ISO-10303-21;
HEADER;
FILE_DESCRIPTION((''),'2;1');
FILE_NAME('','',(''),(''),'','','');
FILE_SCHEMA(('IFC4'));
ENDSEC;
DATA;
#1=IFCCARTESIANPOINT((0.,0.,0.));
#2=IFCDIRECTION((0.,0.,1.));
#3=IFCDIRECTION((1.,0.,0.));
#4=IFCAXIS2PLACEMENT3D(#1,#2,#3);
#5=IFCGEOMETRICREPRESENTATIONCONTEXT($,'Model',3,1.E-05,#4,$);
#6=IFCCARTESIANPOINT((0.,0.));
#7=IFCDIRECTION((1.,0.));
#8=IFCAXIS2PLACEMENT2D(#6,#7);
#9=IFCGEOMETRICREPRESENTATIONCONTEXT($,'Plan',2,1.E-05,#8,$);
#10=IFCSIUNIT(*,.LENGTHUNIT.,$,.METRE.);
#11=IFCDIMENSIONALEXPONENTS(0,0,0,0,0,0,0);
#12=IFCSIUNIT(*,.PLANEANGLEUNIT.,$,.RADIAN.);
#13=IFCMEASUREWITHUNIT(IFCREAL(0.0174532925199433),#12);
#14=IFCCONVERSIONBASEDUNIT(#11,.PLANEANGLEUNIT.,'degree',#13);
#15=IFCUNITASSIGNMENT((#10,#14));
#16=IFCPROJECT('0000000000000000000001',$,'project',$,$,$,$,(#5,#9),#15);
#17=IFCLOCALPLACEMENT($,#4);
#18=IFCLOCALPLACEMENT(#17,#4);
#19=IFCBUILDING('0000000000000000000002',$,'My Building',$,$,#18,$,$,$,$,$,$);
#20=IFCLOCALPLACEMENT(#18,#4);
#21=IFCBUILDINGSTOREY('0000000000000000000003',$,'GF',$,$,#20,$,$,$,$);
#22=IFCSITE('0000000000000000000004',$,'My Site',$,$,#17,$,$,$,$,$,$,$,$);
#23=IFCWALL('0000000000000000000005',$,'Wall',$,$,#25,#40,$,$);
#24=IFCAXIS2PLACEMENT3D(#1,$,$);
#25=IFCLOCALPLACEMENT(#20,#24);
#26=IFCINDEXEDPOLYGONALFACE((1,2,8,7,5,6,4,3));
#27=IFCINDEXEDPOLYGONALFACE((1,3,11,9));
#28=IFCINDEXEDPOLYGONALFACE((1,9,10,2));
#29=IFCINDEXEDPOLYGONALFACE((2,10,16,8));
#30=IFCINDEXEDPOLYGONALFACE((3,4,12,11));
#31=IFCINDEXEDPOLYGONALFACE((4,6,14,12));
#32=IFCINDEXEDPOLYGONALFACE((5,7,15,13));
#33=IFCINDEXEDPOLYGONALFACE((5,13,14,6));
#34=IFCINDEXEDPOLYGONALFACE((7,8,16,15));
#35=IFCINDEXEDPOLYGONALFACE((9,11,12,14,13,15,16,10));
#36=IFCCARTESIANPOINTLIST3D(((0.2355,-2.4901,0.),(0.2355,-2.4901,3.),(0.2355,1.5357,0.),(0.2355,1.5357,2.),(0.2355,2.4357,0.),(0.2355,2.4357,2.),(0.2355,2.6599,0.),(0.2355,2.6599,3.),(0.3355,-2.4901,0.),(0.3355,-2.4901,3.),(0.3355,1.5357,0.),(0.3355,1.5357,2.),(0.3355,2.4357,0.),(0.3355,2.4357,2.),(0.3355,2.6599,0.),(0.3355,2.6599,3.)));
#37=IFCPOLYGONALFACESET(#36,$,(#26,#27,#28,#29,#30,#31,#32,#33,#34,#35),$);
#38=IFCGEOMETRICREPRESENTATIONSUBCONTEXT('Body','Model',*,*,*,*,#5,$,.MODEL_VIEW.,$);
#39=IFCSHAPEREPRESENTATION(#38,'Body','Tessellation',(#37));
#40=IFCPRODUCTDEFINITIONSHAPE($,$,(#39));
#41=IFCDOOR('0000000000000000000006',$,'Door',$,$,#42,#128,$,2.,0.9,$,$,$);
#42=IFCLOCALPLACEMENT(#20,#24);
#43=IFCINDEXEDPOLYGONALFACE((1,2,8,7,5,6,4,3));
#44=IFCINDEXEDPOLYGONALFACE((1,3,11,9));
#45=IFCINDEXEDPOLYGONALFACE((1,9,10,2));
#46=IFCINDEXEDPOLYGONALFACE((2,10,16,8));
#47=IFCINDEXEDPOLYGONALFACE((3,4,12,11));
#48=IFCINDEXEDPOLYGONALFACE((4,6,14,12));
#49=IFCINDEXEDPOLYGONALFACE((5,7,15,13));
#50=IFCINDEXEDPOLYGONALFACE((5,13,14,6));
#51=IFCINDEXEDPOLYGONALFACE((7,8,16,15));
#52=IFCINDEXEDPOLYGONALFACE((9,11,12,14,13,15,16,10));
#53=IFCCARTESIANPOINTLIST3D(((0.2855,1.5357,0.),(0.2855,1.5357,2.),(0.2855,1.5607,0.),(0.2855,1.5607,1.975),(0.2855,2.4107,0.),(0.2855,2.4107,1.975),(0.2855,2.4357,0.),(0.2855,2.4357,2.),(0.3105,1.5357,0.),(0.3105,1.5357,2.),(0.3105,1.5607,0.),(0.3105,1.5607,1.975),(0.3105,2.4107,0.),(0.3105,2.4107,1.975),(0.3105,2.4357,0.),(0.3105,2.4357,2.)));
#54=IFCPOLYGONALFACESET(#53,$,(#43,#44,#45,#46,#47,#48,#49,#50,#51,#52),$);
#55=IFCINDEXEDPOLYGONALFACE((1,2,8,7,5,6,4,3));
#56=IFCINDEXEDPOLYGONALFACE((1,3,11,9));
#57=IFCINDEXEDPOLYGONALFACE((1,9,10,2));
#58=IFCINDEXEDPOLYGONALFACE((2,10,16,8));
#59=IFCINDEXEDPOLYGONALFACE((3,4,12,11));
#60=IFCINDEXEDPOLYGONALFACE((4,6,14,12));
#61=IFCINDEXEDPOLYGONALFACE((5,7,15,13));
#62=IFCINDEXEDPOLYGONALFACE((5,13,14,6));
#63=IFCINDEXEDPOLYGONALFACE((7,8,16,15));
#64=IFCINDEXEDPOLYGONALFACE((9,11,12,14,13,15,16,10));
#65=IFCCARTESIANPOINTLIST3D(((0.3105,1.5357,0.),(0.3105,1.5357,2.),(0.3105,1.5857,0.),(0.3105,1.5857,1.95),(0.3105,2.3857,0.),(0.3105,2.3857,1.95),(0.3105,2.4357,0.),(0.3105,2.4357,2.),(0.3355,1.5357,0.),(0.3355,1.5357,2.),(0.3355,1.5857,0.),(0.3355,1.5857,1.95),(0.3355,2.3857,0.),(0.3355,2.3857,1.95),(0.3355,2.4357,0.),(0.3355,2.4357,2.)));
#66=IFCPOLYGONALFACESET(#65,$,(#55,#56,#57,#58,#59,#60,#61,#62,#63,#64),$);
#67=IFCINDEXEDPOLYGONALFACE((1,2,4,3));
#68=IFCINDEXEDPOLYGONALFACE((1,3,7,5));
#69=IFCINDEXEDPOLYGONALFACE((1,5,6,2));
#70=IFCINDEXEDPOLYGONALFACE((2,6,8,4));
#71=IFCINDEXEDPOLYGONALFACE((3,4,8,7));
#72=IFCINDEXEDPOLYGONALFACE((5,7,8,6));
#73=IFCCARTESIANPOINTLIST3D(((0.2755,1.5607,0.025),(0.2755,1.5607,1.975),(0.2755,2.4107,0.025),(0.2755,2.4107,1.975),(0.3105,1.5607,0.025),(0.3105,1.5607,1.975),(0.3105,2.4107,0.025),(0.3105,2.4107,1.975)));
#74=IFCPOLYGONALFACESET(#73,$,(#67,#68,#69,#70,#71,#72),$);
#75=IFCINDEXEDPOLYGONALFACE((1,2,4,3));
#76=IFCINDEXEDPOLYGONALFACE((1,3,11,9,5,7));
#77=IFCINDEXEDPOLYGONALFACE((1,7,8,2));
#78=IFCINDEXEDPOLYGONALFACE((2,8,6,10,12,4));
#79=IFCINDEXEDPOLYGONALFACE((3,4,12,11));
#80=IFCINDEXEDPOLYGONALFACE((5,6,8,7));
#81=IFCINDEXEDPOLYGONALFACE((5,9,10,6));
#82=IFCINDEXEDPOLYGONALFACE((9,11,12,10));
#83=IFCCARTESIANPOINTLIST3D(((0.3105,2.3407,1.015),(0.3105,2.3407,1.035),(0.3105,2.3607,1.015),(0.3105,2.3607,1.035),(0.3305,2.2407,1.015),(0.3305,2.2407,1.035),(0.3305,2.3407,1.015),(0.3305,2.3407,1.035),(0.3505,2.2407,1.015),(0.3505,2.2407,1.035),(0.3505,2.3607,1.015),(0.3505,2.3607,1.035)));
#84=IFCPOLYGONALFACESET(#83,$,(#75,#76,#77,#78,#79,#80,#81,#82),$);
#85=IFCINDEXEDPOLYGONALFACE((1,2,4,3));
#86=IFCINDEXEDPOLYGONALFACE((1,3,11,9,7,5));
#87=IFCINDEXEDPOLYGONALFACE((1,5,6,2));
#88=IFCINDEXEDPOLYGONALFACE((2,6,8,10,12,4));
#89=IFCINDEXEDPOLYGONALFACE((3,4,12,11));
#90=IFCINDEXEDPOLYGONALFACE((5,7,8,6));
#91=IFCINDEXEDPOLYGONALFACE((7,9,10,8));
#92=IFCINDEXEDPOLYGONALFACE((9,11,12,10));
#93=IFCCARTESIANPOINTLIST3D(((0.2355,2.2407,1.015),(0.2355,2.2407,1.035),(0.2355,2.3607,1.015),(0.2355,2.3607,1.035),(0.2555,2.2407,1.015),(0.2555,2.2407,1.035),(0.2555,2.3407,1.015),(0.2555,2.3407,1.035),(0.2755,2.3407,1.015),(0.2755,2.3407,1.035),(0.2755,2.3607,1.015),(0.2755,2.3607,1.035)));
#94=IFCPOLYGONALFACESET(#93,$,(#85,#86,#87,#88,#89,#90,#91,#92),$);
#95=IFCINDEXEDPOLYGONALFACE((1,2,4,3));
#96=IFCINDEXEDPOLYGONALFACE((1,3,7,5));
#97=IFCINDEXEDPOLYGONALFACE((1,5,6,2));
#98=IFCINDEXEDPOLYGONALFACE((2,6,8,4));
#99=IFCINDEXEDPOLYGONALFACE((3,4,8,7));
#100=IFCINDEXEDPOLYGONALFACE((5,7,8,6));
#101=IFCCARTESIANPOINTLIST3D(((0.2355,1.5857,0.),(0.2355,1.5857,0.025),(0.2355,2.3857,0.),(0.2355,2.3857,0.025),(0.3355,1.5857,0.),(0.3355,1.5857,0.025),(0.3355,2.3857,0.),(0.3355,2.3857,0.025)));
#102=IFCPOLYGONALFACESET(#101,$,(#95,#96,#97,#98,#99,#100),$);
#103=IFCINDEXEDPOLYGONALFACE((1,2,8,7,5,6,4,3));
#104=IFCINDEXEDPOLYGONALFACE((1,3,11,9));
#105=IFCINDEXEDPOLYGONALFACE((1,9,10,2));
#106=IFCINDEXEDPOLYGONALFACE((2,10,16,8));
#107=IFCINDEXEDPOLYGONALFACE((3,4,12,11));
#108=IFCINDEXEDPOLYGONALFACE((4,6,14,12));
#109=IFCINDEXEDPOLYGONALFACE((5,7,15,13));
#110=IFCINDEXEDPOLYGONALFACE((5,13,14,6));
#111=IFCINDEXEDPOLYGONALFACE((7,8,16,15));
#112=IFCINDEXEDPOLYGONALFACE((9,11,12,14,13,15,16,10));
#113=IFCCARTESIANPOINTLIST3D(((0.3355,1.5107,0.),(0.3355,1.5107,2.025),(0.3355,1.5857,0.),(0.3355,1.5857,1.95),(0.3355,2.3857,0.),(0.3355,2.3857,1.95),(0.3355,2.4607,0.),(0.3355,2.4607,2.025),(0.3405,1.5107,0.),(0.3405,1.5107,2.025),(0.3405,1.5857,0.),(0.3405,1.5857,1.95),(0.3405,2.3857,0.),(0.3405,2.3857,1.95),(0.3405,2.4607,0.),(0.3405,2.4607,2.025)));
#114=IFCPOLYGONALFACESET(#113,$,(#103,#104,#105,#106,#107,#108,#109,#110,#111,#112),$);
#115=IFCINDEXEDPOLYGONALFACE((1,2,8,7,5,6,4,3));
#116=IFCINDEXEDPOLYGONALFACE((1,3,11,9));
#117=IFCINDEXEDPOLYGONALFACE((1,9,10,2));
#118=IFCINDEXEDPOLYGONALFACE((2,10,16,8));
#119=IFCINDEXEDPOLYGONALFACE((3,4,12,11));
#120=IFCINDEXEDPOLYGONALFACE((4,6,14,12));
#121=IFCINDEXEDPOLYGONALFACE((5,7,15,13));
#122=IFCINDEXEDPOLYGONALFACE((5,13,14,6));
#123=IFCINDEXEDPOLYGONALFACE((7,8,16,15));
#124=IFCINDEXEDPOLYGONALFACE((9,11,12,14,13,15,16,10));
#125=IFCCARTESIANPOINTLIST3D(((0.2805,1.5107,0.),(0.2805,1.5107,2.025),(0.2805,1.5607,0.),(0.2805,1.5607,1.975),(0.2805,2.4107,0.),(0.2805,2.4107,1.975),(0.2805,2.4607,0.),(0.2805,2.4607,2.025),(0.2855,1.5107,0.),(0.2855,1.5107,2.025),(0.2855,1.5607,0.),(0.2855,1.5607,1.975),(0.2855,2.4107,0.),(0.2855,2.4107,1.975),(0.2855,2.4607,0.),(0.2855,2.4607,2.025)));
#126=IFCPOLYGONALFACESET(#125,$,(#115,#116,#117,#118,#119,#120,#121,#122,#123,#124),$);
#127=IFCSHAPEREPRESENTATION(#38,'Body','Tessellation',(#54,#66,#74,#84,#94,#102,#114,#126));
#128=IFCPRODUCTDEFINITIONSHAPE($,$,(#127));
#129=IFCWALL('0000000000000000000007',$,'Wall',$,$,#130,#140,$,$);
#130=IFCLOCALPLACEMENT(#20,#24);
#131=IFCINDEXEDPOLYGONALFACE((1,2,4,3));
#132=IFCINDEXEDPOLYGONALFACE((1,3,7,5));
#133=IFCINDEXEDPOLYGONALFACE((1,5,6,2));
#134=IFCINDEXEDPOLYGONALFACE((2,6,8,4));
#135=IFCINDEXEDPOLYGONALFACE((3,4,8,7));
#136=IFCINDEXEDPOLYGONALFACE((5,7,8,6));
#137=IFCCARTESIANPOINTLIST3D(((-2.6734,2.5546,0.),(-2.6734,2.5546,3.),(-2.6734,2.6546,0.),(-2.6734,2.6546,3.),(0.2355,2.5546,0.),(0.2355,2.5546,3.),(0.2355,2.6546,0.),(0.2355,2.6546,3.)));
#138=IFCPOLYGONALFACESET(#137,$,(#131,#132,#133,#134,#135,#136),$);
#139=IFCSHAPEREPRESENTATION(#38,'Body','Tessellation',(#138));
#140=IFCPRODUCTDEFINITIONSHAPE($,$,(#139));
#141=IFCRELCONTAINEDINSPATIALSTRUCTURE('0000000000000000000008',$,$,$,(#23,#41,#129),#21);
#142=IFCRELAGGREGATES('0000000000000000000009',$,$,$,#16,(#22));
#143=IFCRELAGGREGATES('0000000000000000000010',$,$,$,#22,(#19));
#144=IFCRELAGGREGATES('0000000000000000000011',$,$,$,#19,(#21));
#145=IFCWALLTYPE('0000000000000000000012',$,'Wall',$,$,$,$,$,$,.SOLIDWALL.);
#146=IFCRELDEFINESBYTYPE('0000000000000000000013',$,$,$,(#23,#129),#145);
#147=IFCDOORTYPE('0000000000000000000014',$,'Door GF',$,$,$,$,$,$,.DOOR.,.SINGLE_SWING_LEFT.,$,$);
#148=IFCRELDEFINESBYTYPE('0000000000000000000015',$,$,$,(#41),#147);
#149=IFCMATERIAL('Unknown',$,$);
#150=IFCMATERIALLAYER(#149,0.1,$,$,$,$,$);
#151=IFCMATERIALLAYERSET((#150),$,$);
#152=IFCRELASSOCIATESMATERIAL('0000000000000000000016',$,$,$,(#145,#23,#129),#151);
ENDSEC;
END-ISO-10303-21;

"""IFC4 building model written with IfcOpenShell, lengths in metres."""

from ifc_helpers import new_model, entity, si_unit, converted_unit, frame, origin_with_axes, origin_2d_with_axis, place, context, subcontext, project, spatial, line, indexed_curve, outline, extrude, shape, source, transform, mapped, material, layer, layer_set, layer_usage, type_object, type_shapes, element, fill, save


model = new_model("IFC4")

# Units and contexts
model_context = context("Model", 3, precision=1e-05, world=origin_with_axes())
plan_context = context("Plan", 2, precision=1e-05, world=origin_2d_with_axis())
body_context_1 = subcontext(model_context, "Body", "Model", "MODEL_VIEW")
body_context_2 = subcontext(plan_context, "Body", "Plan", "PLAN_VIEW")
ifc_project = project(units=[si_unit("LENGTHUNIT", "METRE"), converted_unit("PLANEANGLEUNIT", "degree", entity("IfcReal", 0.0174532925199433), si_unit("PLANEANGLEUNIT", "RADIAN"), dimensions=[0, 0, 0, 0, 0, 0, 0])], contexts=[model_context, plan_context])

# Site, building, storey
site_placement = place(None, origin_with_axes())
site = spatial("IfcSite", under=ifc_project, at=site_placement, Name="My Site")
building_placement = place(site_placement, origin_with_axes())
building = spatial("IfcBuilding", under=site, at=building_placement, Name="My Building")
storey_placement = place(building_placement, origin_with_axes())
storey = spatial("IfcBuildingStorey", under=building, at=storey_placement, Name="GF")

# Shared definitions
ifc_material = material(Name="Unknown")

# Shared definitions
ifc_layer_1 = layer(ifc_material, 0.1)
ifc_layer_set_1 = layer_set([ifc_layer_1])
wall_type = type_object("IfcWallType", Name="Wall", PredefinedType="SOLIDWALL", material=ifc_layer_set_1)
shared_shape_1 = source(origin_with_axes(), body_context_1, "Body", "SweptSolid", [
    extrude(outline(indexed_curve([(0.0, 0.0), (0.9, 0.0), (0.9, 2.0), (0.0, 2.0)], segments=[line(1, 2, 3, 4, 1)])), frame((0.0, -0.6, 0.0), z_axis=(0.0, -1.0, 0.0), x_axis=(1.0, 0.0, 0.0)), (0.0, 0.0, -1.0), 1.2),
])
door_type = type_object("IfcDoorType", Name="Door GF", OperationType="SINGLE_SWING_LEFT", PredefinedType="DOOR")
shared_shape_2 = source(origin_with_axes(), body_context_1, "Body", "SweptSolid", [
    extrude(outline(indexed_curve([(0.0, 0.0), (0.0, 2.0), (0.9, 2.0), (0.9, 0.0), (0.875, 0.0), (0.875, 1.975), (0.025, 1.975), (0.025, 0.0)], segments=[line(1, 2, 3, 4, 5, 6, 7, 8, 1)])), frame((0.0, 0.025, 0.0), z_axis=(0.0, -1.0, 0.0), x_axis=(1.0, 0.0, 0.0)), (0.0, 0.0, -1.0), 0.025),
    extrude(outline(indexed_curve([(0.0, 0.0), (0.0, 2.0), (0.9, 2.0), (0.9, 0.0), (0.85, 0.0), (0.85, 1.95), (0.05, 1.95), (0.05, 0.0)], segments=[line(1, 2, 3, 4, 5, 6, 7, 8, 1)])), frame((0.0, 0.0, 0.0), z_axis=(0.0, -1.0, 0.0), x_axis=(1.0, 0.0, 0.0)), (0.0, 0.0, -1.0), 0.025),
    extrude(outline(indexed_curve([(0.0, 0.0), (0.85, 0.0), (0.85, 0.035), (0.0, 0.035)], segments=[line(1, 2, 3, 4, 1)])), frame((0.025, 0.025, 0.025), z_axis=(0.0, 0.0, 1.0), x_axis=(1.0, 0.0, 0.0)), (0.0, 0.0, 1.0), 1.95),
    extrude(outline(indexed_curve([(0.0, 0.0), (0.0, -0.04), (-0.12, -0.04), (-0.12, -0.02), (-0.02, -0.02), (-0.02, 0.0)], segments=[line(1, 2, 3, 4, 5, 6, 1)])), frame((0.825, 0.025, 1.015), z_axis=(0.0, 0.0, 1.0), x_axis=(1.0, 0.0, 0.0)), (0.0, 0.0, 1.0), 0.02),
    extrude(outline(indexed_curve([(0.0, 0.0), (0.0, 0.04), (-0.12, 0.04), (-0.12, 0.02), (-0.02, 0.02), (-0.02, 0.0)], segments=[line(1, 2, 3, 4, 5, 6, 1)])), frame((0.825, 0.06, 1.015), z_axis=(0.0, 0.0, 1.0), x_axis=(1.0, 0.0, 0.0)), (0.0, 0.0, 1.0), 0.02),
    extrude(outline(indexed_curve([(0.0, 0.0), (0.8, 0.0), (0.8, 0.1), (0.0, 0.1)], segments=[line(1, 2, 3, 4, 1)])), frame((0.05, 0.0, 0.0), z_axis=(0.0, 0.0, 1.0), x_axis=(1.0, 0.0, 0.0)), (0.0, 0.0, 1.0), 0.025),
    extrude(outline(indexed_curve([(0.0, 0.0), (0.0, 2.025), (0.95, 2.025), (0.95, 0.0), (0.875, 0.0), (0.875, 1.95), (0.075, 1.95), (0.075, 0.0)], segments=[line(1, 2, 3, 4, 5, 6, 7, 8, 1)])), frame((-0.025, -0.005, 0.0), z_axis=(0.0, -1.0, 0.0), x_axis=(1.0, 0.0, 0.0)), (0.0, 0.0, -1.0), 0.005),
    extrude(outline(indexed_curve([(0.0, 0.0), (0.0, 2.025), (0.95, 2.025), (0.95, 0.0), (0.9, 0.0), (0.9, 1.975), (0.05, 1.975), (0.05, 0.0)], segments=[line(1, 2, 3, 4, 5, 6, 7, 8, 1)])), frame((-0.025, 0.05, 0.0), z_axis=(0.0, -1.0, 0.0), x_axis=(1.0, 0.0, 0.0)), (0.0, 0.0, -1.0), 0.005),
])
shared_shape_3 = source(origin_with_axes(), body_context_2, "Body", "Curve2D", [
    entity("IfcIndexedPolyCurve", entity("IfcCartesianPointList2D", [[0.0, 0.0], [0.0, 0.05], [0.025, 0.05], [0.025, 0.025], [0.05, 0.025], [0.05, 0.0]]), [entity("IfcLineIndex", [1, 2, 3, 4, 5, 6, 1])]),
    entity("IfcIndexedPolyCurve", entity("IfcCartesianPointList2D", [[0.9, 0.0], [0.9, 0.05], [0.875, 0.05], [0.875, 0.025], [0.85, 0.025], [0.85, 0.0]]), [entity("IfcLineIndex", [1, 2, 3, 4, 5, 6, 1])]),
    entity("IfcTrimmedCurve", entity("IfcEllipse", entity("IfcAxis2Placement2D", entity("IfcCartesianPoint", [0.06, 0.05]), entity("IfcDirection", [1.0, 0.0])), 0.815, 0.85), [entity("IfcCartesianPoint", [0.875, 0.05])], [entity("IfcCartesianPoint", [0.06, 0.9])], True, "CARTESIAN"),
    entity("IfcIndexedPolyCurve", entity("IfcCartesianPointList2D", [[0.025, 0.05], [0.06, 0.05], [0.06, 0.9], [0.025, 0.9]]), [entity("IfcLineIndex", [1, 2, 3, 4, 1])]),
])
type_shapes(door_type, [shared_shape_2, shared_shape_3])

# Wall, opening, door
ifc_layer_usage_1 = layer_usage(ifc_layer_set_1, "AXIS2", "POSITIVE", 0.0)
wall_1_placement = place(storey_placement, frame((0.3355, -2.4901, 0.0), z_axis=(0.0, 0.0, 1.0), x_axis=(0.0, 1.0, 0.0)))
wall_1 = element("IfcWall", 1, at=wall_1_placement, inside=storey, type_object=wall_type, material=ifc_layer_usage_1, Name="Wall", context=body_context_1, shape_type="SweptSolid", body=[
    extrude(outline(indexed_curve([(0.0, 0.0), (0.0, 0.1), (5.15, 0.1), (5.15, 0.0)], segments=[line(1, 2, 3, 4, 1)])), origin_with_axes(), (0.0, 0.0, 1.0), 3.0),
])
opening_1_placement = place(wall_1_placement, frame((4.0258, 0.0, 0.0), z_axis=(0.0, 0.0, 1.0), x_axis=(1.0, 0.0, 0.0)))
opening_1 = element("IfcOpeningElement", 2, at=opening_1_placement, cuts=wall_1, PredefinedType="OPENING", context=body_context_1, shape_type="MappedRepresentation", body=[
    mapped(shared_shape_1, transform((0.0, 0.0, 0.0), x_axis=(1.0, 0.0, 0.0), y_axis=(0.0, 1.0, 0.0), z_axis=(0.0, 0.0, 1.0), scale=1.0)),
])
door_1_placement = place(opening_1_placement, frame((0.0, 0.0, 0.0), z_axis=(0.0, 0.0, 1.0), x_axis=(1.0, 0.0, 0.0)))
door_1 = element("IfcDoor", 3, at=door_1_placement, inside=storey, type_object=door_type, Name="Door", OverallHeight=2.0, OverallWidth=0.9, shapes=[
    shape(body_context_1, "Body", "MappedRepresentation", [mapped(shared_shape_2, transform((0.0, 0.0, 0.0), x_axis=(1.0, 0.0, 0.0), y_axis=(0.0, 1.0, 0.0), z_axis=(0.0, 0.0, 1.0), scale=1.0))]),
    shape(body_context_2, "Body", "MappedRepresentation", [mapped(shared_shape_3, transform((0.0, 0.0, 0.0), x_axis=(1.0, 0.0, 0.0), y_axis=(0.0, 1.0, 0.0), z_axis=(0.0, 0.0, 1.0), scale=1.0))]),
])
fill(opening_1, door_1)

# Wall
ifc_layer_usage_2 = layer_usage(ifc_layer_set_1, "AXIS2", "POSITIVE", 0.0)
wall_2_placement = place(storey_placement, frame((0.2355, 2.6546, 0.0), z_axis=(0.0, 0.0, 1.0), x_axis=(-1.0, 0.0, 0.0)))
element("IfcWall", 4, at=wall_2_placement, inside=storey, type_object=wall_type, material=ifc_layer_usage_2, Name="Wall", context=body_context_1, shape_type="SweptSolid", body=[
    extrude(outline(indexed_curve([(0.0, 0.0), (0.0, 0.1), (2.9089, 0.1), (2.9089, 0.0)], segments=[line(1, 2, 3, 4, 1)])), origin_with_axes(), (0.0, 0.0, 1.0), 3.0),
])

save(model, "model.ifc")
